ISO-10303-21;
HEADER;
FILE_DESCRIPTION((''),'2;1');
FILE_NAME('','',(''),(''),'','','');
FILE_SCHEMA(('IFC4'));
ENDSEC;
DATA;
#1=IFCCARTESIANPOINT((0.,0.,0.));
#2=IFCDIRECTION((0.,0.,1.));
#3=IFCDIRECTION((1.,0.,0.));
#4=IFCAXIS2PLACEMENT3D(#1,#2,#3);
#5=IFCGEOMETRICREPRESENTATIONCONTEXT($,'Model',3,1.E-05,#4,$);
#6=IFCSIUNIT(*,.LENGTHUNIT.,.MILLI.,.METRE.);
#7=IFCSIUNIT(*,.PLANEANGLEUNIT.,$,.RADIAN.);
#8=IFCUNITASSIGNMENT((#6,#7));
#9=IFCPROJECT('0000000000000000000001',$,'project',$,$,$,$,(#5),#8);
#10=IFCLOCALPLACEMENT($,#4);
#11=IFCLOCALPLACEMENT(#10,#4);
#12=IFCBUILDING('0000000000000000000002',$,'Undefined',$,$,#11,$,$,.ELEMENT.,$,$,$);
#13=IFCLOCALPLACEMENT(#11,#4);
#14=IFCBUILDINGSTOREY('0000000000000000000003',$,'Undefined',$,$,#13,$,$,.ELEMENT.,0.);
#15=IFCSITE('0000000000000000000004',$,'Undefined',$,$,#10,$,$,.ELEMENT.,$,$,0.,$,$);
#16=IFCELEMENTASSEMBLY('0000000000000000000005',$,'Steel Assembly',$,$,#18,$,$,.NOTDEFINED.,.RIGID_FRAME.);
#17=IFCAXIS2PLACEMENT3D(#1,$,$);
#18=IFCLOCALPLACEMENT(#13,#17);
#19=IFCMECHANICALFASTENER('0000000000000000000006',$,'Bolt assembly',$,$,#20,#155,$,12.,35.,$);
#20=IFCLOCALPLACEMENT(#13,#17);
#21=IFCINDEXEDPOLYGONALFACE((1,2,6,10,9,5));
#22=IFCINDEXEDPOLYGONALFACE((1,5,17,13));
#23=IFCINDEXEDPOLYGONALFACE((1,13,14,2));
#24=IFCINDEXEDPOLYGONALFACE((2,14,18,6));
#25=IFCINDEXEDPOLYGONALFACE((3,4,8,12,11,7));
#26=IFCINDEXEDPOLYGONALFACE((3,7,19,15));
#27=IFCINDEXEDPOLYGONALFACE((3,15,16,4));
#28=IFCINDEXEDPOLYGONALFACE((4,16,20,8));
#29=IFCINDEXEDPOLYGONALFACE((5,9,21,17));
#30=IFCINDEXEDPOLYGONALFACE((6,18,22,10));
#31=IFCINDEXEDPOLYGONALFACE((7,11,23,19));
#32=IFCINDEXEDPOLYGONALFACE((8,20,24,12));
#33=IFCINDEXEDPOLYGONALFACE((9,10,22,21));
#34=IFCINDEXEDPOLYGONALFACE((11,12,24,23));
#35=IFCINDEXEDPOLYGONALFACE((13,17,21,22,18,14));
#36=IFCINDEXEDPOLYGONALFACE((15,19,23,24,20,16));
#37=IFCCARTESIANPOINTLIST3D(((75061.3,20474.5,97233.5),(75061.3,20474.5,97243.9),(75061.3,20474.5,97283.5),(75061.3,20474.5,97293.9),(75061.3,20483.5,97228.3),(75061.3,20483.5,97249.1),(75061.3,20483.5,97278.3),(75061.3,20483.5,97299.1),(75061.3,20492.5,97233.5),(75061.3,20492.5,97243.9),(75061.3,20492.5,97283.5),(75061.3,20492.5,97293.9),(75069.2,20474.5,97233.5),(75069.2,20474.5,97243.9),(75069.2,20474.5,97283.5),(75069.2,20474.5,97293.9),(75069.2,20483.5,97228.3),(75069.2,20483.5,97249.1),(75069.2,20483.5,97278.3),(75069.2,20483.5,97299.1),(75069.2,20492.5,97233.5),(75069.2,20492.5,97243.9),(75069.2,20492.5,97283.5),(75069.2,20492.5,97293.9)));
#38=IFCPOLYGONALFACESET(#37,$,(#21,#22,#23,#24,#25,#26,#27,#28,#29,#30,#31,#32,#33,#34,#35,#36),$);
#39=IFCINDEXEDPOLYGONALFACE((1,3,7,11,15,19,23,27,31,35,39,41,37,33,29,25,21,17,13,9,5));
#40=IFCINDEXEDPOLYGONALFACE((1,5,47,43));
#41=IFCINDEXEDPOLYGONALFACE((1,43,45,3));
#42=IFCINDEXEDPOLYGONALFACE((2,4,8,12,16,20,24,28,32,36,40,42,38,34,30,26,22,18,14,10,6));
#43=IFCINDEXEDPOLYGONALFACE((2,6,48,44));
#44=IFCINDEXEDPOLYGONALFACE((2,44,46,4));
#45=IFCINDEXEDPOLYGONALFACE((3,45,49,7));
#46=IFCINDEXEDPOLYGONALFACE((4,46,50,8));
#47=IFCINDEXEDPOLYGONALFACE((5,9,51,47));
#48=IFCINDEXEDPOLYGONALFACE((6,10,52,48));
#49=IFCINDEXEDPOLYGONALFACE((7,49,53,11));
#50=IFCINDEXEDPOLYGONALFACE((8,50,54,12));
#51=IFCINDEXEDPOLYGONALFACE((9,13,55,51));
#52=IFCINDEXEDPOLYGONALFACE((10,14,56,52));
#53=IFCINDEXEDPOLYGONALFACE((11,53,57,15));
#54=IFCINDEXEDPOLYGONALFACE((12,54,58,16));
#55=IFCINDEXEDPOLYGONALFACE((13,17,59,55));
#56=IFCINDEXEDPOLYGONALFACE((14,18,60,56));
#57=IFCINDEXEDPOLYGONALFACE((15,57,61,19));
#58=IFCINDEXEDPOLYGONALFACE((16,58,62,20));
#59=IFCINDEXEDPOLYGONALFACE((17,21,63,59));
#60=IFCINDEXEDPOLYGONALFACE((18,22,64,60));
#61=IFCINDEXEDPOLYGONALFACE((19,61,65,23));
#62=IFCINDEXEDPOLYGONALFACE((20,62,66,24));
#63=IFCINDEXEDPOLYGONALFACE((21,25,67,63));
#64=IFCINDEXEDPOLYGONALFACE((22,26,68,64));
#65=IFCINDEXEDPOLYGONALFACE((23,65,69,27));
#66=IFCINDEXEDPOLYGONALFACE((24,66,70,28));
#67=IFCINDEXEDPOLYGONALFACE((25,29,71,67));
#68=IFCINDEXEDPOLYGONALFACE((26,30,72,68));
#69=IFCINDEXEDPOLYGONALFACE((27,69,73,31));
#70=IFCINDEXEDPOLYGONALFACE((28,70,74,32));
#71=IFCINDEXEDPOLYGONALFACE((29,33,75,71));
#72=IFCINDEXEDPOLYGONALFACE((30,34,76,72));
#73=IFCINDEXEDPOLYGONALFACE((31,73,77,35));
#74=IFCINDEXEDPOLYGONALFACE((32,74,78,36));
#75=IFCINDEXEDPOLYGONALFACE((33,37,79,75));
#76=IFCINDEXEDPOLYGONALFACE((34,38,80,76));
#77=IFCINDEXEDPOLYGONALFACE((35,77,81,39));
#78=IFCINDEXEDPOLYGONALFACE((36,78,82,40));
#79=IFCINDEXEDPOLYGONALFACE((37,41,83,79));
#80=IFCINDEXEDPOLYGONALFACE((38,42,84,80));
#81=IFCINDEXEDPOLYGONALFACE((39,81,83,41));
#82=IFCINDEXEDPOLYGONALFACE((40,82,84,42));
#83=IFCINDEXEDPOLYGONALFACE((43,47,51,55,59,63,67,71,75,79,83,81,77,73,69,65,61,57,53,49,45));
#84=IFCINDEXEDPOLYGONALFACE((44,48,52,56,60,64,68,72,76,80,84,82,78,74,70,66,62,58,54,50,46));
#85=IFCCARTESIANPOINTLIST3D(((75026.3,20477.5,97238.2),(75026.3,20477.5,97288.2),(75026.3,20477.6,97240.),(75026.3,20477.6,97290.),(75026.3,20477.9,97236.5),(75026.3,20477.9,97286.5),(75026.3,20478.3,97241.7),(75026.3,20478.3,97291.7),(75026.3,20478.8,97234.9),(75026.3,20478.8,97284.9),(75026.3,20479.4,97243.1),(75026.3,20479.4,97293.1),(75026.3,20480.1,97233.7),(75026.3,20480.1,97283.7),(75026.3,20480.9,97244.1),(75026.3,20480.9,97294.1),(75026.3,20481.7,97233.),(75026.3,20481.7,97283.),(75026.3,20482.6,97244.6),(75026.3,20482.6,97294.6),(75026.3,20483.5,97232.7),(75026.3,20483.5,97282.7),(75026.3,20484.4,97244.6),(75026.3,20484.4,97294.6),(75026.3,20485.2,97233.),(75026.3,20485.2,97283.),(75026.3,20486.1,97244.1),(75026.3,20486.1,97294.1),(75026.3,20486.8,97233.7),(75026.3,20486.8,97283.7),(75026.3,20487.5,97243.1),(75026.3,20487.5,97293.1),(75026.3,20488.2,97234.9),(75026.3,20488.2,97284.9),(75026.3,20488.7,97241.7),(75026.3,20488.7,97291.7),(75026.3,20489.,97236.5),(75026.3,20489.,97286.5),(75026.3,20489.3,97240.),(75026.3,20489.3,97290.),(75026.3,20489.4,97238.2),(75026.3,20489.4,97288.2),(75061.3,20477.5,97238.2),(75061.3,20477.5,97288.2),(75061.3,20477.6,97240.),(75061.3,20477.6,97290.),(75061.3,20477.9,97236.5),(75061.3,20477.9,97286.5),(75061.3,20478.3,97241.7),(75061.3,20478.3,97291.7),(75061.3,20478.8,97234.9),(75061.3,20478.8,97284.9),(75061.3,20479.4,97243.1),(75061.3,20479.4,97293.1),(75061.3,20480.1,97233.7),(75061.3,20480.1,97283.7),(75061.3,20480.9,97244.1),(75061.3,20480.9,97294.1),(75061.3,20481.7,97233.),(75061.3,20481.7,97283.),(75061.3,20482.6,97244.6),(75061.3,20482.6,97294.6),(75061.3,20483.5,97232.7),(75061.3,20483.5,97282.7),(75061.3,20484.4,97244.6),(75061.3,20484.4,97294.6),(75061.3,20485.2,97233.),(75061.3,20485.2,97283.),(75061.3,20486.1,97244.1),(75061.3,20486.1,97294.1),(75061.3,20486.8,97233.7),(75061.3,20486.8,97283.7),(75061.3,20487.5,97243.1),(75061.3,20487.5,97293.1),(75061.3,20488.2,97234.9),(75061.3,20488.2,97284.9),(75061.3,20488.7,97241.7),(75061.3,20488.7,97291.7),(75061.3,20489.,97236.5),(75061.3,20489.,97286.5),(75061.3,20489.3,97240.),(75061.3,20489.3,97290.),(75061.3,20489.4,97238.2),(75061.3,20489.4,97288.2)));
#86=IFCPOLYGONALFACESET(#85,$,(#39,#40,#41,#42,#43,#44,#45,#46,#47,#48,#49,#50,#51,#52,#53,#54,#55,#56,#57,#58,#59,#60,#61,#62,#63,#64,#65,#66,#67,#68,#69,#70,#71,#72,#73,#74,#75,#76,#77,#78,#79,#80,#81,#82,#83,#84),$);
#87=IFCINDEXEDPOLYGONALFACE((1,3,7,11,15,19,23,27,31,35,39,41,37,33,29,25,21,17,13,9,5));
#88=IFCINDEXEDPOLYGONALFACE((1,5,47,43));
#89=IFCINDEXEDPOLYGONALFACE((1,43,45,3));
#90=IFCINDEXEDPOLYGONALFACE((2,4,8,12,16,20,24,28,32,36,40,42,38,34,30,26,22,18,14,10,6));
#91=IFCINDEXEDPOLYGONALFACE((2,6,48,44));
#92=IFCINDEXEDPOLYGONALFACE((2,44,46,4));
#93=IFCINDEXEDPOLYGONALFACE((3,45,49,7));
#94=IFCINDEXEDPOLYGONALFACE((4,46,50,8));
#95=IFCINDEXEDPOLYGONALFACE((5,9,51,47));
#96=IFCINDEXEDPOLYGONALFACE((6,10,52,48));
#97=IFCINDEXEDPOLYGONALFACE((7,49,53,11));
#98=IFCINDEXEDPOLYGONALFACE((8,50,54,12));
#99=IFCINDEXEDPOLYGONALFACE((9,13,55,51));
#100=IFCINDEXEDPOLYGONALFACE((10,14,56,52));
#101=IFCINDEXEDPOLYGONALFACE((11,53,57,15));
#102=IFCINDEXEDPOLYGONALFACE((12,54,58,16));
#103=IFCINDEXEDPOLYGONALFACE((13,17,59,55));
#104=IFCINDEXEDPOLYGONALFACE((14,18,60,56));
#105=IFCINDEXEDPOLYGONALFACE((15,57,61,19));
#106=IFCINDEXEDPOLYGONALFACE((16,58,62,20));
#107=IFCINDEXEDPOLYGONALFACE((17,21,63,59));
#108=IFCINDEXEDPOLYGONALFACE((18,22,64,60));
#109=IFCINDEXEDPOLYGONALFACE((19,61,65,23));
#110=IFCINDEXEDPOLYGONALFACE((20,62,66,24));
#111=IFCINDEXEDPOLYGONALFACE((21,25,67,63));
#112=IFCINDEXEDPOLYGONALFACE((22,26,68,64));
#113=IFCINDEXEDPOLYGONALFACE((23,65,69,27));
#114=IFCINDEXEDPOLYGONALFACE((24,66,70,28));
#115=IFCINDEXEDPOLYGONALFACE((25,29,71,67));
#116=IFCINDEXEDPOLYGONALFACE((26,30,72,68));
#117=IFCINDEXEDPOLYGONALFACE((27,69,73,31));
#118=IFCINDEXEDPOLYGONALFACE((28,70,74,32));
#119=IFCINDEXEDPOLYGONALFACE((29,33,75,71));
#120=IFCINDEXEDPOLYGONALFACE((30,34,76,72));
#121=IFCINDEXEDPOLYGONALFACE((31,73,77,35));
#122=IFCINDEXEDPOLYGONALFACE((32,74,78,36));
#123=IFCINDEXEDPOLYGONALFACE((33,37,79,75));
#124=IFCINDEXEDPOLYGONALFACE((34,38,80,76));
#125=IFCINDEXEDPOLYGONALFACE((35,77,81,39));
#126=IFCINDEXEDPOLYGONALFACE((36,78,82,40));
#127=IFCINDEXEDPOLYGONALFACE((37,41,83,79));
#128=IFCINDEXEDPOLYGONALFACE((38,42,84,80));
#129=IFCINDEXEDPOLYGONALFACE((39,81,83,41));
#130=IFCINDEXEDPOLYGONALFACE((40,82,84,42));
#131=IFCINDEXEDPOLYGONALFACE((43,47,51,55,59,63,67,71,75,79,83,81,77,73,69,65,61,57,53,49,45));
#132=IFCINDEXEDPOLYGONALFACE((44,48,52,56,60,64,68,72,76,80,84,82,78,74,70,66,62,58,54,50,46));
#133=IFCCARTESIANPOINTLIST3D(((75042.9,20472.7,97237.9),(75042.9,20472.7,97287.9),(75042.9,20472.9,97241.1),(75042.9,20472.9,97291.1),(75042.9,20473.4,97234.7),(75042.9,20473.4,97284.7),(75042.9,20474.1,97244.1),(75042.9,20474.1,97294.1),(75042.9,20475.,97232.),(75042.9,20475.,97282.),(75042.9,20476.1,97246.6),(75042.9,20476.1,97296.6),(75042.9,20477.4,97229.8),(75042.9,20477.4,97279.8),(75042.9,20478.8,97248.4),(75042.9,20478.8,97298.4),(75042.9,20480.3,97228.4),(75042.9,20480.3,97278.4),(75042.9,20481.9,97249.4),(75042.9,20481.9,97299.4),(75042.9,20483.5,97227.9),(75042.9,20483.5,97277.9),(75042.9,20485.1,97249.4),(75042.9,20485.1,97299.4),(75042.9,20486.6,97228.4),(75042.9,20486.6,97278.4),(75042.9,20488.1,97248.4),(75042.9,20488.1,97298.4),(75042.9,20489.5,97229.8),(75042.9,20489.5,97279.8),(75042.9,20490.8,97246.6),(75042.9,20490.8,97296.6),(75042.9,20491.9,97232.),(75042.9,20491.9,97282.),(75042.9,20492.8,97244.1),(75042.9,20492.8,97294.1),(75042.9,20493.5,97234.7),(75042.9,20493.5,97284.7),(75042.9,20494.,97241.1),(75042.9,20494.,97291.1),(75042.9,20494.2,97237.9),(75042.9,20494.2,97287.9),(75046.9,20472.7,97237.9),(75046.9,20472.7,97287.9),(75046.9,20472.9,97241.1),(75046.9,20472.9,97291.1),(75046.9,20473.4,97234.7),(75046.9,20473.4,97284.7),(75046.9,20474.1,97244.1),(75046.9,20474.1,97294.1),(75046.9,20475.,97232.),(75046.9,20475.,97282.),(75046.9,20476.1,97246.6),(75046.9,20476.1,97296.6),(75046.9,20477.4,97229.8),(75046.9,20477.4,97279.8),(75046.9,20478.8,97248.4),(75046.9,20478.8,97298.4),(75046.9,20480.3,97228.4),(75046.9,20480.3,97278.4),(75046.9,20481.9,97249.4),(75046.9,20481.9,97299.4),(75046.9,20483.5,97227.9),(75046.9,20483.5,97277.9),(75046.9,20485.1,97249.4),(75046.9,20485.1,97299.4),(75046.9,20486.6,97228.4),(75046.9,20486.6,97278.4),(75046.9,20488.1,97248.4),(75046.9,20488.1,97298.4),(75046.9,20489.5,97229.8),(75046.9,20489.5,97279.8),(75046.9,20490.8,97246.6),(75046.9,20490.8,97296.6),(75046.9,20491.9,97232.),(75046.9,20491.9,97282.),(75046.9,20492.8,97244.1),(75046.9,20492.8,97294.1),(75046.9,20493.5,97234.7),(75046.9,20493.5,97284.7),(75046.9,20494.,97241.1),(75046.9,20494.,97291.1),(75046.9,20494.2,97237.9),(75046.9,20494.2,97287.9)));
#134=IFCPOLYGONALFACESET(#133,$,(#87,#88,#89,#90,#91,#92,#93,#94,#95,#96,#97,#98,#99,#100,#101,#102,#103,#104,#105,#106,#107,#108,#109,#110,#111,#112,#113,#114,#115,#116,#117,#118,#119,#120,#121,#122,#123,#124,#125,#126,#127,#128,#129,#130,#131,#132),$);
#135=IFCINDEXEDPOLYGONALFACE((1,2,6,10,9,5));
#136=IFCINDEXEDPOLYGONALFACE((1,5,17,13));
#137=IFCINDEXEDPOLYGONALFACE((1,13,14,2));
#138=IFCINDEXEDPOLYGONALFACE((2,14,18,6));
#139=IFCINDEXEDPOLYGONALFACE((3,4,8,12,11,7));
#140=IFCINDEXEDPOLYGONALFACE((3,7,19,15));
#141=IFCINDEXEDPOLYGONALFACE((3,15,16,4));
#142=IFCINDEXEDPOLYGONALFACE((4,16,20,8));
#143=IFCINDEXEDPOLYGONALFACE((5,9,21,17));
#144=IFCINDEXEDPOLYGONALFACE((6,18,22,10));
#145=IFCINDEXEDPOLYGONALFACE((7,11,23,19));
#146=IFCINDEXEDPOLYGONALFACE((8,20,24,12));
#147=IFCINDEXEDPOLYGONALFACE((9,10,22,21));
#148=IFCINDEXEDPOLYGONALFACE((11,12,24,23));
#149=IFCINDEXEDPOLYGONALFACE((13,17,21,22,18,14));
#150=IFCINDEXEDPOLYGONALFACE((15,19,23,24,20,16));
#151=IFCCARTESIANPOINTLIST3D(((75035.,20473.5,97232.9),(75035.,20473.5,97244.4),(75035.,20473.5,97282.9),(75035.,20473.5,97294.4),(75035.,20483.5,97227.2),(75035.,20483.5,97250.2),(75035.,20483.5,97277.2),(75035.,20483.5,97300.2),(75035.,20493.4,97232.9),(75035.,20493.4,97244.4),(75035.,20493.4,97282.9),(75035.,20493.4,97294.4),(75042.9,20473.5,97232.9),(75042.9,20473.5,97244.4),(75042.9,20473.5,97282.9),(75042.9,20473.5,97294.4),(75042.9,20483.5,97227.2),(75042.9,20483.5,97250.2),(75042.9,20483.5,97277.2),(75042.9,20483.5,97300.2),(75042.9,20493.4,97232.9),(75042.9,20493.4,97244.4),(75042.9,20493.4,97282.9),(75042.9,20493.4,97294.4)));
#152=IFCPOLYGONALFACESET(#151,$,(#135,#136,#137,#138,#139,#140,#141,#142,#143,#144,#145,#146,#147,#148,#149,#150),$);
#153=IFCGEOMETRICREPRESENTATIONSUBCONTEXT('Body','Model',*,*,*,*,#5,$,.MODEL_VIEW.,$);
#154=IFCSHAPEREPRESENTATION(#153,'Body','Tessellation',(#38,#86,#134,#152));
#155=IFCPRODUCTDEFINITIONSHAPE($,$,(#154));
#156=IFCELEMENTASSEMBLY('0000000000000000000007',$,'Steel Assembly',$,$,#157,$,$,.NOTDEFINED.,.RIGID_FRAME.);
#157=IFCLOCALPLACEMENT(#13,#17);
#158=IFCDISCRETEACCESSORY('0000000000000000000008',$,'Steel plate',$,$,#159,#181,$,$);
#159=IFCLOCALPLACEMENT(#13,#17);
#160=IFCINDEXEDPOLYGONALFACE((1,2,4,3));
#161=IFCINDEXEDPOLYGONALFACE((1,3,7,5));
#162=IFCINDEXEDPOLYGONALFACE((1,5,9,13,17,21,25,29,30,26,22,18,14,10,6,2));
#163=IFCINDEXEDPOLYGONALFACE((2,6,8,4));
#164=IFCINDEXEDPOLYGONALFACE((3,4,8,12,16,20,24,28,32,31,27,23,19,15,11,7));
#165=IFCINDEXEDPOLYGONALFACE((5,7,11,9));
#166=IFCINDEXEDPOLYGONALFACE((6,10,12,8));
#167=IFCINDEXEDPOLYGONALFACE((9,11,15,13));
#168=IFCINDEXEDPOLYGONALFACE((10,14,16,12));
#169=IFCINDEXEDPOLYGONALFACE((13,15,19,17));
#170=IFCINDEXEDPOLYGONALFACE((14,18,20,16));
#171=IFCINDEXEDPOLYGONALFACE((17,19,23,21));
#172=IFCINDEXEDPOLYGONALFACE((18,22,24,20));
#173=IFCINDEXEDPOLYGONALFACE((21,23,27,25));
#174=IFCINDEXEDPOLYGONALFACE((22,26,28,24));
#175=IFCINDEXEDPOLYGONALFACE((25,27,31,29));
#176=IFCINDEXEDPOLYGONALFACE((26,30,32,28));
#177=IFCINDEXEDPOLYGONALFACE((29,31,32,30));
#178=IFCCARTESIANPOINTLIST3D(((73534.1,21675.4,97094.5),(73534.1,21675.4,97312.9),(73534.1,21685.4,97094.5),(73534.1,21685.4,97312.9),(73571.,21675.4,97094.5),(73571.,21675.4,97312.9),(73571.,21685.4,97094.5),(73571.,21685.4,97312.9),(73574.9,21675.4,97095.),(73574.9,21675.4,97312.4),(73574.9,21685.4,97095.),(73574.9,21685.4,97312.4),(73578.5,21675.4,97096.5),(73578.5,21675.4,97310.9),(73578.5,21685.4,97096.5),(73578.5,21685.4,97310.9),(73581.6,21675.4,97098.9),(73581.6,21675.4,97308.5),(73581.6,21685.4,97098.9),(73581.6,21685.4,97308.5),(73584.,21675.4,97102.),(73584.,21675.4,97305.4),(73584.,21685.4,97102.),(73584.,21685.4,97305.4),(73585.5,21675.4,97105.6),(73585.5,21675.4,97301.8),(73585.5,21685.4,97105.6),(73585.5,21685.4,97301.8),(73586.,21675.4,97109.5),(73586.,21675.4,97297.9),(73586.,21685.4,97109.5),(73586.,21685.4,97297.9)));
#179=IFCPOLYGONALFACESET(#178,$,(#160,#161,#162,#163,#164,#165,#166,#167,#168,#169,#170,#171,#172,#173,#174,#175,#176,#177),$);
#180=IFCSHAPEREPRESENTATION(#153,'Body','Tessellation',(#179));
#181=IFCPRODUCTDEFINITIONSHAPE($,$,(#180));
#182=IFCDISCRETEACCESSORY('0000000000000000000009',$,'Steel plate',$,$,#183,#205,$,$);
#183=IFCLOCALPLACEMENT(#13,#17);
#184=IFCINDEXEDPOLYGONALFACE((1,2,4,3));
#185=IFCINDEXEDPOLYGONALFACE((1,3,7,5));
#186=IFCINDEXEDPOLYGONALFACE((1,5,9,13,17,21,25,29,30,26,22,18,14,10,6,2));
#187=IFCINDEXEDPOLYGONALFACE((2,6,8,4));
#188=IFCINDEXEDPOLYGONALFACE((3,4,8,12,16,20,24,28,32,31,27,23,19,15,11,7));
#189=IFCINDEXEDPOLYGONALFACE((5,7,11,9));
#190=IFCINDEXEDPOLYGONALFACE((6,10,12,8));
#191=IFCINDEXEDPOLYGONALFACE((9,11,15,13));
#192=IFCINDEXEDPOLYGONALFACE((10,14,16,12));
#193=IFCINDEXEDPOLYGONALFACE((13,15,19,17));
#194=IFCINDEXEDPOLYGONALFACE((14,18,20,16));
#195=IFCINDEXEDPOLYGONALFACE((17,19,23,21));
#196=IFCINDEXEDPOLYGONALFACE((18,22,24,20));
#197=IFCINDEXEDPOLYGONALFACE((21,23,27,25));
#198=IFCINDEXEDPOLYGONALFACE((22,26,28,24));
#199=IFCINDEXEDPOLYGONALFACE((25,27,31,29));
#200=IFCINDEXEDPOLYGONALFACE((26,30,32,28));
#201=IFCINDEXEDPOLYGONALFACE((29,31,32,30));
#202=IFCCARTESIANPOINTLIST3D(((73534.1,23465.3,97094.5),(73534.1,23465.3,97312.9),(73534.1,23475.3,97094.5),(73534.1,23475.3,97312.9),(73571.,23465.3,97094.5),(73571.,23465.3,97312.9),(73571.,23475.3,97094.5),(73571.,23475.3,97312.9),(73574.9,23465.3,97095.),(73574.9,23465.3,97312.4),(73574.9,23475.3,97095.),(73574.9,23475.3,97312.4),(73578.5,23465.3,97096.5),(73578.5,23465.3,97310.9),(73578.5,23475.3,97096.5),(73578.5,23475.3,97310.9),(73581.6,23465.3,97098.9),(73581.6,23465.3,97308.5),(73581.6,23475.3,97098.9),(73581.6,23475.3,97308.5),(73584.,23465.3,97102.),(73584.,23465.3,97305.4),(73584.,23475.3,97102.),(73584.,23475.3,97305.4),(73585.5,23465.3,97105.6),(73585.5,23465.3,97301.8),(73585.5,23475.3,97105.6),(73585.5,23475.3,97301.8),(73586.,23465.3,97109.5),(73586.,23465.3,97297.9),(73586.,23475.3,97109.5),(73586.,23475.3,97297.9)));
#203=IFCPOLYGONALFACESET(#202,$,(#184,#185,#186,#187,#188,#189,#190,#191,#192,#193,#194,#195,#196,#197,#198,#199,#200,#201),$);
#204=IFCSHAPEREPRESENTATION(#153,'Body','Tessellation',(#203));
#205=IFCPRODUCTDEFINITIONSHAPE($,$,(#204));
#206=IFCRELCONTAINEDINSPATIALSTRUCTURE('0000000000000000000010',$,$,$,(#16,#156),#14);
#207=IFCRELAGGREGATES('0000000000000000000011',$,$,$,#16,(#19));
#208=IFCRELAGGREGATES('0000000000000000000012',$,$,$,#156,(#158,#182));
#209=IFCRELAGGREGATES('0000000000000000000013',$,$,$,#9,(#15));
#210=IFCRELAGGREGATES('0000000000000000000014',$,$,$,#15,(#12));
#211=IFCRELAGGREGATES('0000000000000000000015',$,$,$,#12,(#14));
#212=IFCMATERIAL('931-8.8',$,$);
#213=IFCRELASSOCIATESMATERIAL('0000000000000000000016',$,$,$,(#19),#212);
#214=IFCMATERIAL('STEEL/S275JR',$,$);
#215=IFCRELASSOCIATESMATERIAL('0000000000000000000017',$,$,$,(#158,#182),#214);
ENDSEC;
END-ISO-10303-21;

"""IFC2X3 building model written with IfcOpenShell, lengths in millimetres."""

from ifc_helpers import new_model, si_unit, frame, frame_2d, origin_with_axes, origin_2d_with_axis, place, context, subcontext, project, spatial, polyline, circle_curve, parameter, trimmed, segment, composite_curve, circle, outline, extrude, source, transform, mapped, material, element, aggregate, save


model = new_model("IFC2X3")

# Units and contexts
model_context = context("Model", 3, precision=1e-05, world=origin_with_axes())
body_context = subcontext(model_context, "Body", "Model", "MODEL_VIEW")
ifc_project = project(units=[si_unit("LENGTHUNIT", "METRE", prefix="MILLI"), si_unit("PLANEANGLEUNIT", "RADIAN")], contexts=[model_context])

# Site, building, storey
site_placement = place(None, origin_with_axes())
site = spatial("IfcSite", under=ifc_project, at=site_placement, Name="Undefined", CompositionType="ELEMENT", RefElevation=0.0)
building_placement = place(site_placement, origin_with_axes())
building = spatial("IfcBuilding", under=site, at=building_placement, Name="Undefined", CompositionType="ELEMENT")
storey_placement = place(building_placement, origin_with_axes())
storey = spatial("IfcBuildingStorey", under=building, at=storey_placement, Name="Undefined", CompositionType="ELEMENT", Elevation=0.0)

# Shared definitions
ifc_material_1 = material(Name="931-8.8")

# Element assembly
assembly_1_placement = place(storey_placement, origin_with_axes())
assembly_1 = element("IfcElementAssembly", 1, at=assembly_1_placement, inside=storey, Name="Steel Assembly", AssemblyPlace="NOTDEFINED", PredefinedType="RIGID_FRAME")
shared_shape_1 = source(origin_with_axes(), body_context, "Body", "SweptSolid", [
    extrude(outline(polyline([(10.4, 0.0), (5.2, 9.0), (-5.2, 9.0), (-10.4, 0.0), (-5.2, -9.0), (5.2, -9.0), (10.4, 0.0)])), frame((0.0, -22.3, 0.0), z_axis=(0.0, 1.0, 0.0), x_axis=(1.0, 0.0, 0.0)), (0.0, 0.0, 1.0), 7.9),
    extrude(circle(Radius=6.0, at=origin_2d_with_axis()), frame((0.0, -14.4, 0.0), z_axis=(0.0, 1.0, 0.0), x_axis=(1.0, 0.0, 0.0)), (0.0, 0.0, 1.0), 35.0),
    extrude(circle(Radius=10.8, at=origin_2d_with_axis()), frame((0.0, 0.0, 0.0), z_axis=(0.0, 1.0, 0.0), x_axis=(1.0, 0.0, 0.0)), (0.0, 0.0, 1.0), 4.0),
    extrude(outline(polyline([(11.5, 0.0), (5.8, 10.0), (-5.8, 10.0), (-11.5, 0.0), (-5.8, -10.0), (5.8, -10.0), (11.5, 0.0)])), frame((0.0, 4.0, 0.0), z_axis=(0.0, 1.0, 0.0), x_axis=(1.0, 0.0, 0.0)), (0.0, 0.0, 1.0), 7.9),
])

# Mechanical fastener
mechanical_fastener_1_placement = place(assembly_1_placement, frame((75046.9, 20483.5, 97288.7), z_axis=(0.0, 1.0, 0.0), x_axis=(0.0, 0.0, -1.0)))
mechanical_fastener_1 = element("IfcMechanicalFastener", 2, at=mechanical_fastener_1_placement, material=ifc_material_1, Name="Bolt assembly", NominalDiameter=12.0, NominalLength=35.0, context=body_context, shape_type="MappedRepresentation", body=[
    mapped(shared_shape_1, transform((0.0, 0.0, 0.0))),
    mapped(shared_shape_1, transform((50.0, 0.0, 0.0))),
])
aggregate(assembly_1, [mechanical_fastener_1])

# Element assembly, discrete accessories
assembly_2_placement = place(storey_placement, origin_with_axes())
assembly_2 = element("IfcElementAssembly", 3, at=assembly_2_placement, inside=storey, Name="Steel Assembly", AssemblyPlace="NOTDEFINED", PredefinedType="RIGID_FRAME")
ifc_material_2 = material(Name="STEEL/S275JR")
discrete_accessory_1_placement = place(assembly_2_placement, frame((73586.0, 21680.4, 97312.9), z_axis=(0.0, -1.0, 0.0), x_axis=(-1.0, 0.0, 0.0)))
discrete_accessory_1 = element("IfcDiscreteAccessory", 4, at=discrete_accessory_1_placement, material=ifc_material_2, Name="Steel plate", context=body_context, shape_type="SweptSolid", body=[
    extrude(outline(composite_curve([segment(trimmed(circle_curve(frame_2d((15.0, 15.0), x_axis=(-1.0, 0.0)), 15.0), [parameter(0.0)], [parameter(1.570796)], True, "PARAMETER"), True, "CONTINUOUS"), segment(polyline([(15.0, 0.0), (51.9, 0.0), (51.9, 218.4), (15.0, 218.4)]), True, "CONTINUOUS"), segment(trimmed(circle_curve(frame_2d((15.0, 203.4), x_axis=(0.0, 1.0)), 15.0), [parameter(0.0)], [parameter(1.570796)], True, "PARAMETER"), True, "CONTINUOUS"), segment(polyline([(0.0, 203.4), (0.0, 15.0)]), True, "DISCONTINUOUS")], self_intersect=False)), frame((0.0, 0.0, -5.0), z_axis=(0.0, 0.0, 1.0), x_axis=(1.0, 0.0, 0.0)), (0.0, 0.0, 1.0), 10.0),
])
discrete_accessory_2_placement = place(assembly_2_placement, frame((73586.0, 23470.3, 97312.9), z_axis=(0.0, -1.0, 0.0), x_axis=(-1.0, 0.0, 0.0)))
discrete_accessory_2 = element("IfcDiscreteAccessory", 5, at=discrete_accessory_2_placement, material=ifc_material_2, Name="Steel plate", context=body_context, shape_type="SweptSolid", body=[
    extrude(outline(composite_curve([segment(trimmed(circle_curve(frame_2d((15.0, 15.0), x_axis=(-1.0, 0.0)), 15.0), [parameter(0.0)], [parameter(1.570796)], True, "PARAMETER"), True, "CONTINUOUS"), segment(polyline([(15.0, 0.0), (51.9, 0.0), (51.9, 218.4), (15.0, 218.4)]), True, "CONTINUOUS"), segment(trimmed(circle_curve(frame_2d((15.0, 203.4), x_axis=(0.0, 1.0)), 15.0), [parameter(0.0)], [parameter(1.570796)], True, "PARAMETER"), True, "CONTINUOUS"), segment(polyline([(0.0, 203.4), (0.0, 15.0)]), True, "DISCONTINUOUS")], self_intersect=False)), frame((0.0, 0.0, -5.0), z_axis=(0.0, 0.0, 1.0), x_axis=(1.0, 0.0, 0.0)), (0.0, 0.0, 1.0), 10.0),
])

aggregate(assembly_2, [discrete_accessory_1, discrete_accessory_2])

save(model, "model.ifc")
